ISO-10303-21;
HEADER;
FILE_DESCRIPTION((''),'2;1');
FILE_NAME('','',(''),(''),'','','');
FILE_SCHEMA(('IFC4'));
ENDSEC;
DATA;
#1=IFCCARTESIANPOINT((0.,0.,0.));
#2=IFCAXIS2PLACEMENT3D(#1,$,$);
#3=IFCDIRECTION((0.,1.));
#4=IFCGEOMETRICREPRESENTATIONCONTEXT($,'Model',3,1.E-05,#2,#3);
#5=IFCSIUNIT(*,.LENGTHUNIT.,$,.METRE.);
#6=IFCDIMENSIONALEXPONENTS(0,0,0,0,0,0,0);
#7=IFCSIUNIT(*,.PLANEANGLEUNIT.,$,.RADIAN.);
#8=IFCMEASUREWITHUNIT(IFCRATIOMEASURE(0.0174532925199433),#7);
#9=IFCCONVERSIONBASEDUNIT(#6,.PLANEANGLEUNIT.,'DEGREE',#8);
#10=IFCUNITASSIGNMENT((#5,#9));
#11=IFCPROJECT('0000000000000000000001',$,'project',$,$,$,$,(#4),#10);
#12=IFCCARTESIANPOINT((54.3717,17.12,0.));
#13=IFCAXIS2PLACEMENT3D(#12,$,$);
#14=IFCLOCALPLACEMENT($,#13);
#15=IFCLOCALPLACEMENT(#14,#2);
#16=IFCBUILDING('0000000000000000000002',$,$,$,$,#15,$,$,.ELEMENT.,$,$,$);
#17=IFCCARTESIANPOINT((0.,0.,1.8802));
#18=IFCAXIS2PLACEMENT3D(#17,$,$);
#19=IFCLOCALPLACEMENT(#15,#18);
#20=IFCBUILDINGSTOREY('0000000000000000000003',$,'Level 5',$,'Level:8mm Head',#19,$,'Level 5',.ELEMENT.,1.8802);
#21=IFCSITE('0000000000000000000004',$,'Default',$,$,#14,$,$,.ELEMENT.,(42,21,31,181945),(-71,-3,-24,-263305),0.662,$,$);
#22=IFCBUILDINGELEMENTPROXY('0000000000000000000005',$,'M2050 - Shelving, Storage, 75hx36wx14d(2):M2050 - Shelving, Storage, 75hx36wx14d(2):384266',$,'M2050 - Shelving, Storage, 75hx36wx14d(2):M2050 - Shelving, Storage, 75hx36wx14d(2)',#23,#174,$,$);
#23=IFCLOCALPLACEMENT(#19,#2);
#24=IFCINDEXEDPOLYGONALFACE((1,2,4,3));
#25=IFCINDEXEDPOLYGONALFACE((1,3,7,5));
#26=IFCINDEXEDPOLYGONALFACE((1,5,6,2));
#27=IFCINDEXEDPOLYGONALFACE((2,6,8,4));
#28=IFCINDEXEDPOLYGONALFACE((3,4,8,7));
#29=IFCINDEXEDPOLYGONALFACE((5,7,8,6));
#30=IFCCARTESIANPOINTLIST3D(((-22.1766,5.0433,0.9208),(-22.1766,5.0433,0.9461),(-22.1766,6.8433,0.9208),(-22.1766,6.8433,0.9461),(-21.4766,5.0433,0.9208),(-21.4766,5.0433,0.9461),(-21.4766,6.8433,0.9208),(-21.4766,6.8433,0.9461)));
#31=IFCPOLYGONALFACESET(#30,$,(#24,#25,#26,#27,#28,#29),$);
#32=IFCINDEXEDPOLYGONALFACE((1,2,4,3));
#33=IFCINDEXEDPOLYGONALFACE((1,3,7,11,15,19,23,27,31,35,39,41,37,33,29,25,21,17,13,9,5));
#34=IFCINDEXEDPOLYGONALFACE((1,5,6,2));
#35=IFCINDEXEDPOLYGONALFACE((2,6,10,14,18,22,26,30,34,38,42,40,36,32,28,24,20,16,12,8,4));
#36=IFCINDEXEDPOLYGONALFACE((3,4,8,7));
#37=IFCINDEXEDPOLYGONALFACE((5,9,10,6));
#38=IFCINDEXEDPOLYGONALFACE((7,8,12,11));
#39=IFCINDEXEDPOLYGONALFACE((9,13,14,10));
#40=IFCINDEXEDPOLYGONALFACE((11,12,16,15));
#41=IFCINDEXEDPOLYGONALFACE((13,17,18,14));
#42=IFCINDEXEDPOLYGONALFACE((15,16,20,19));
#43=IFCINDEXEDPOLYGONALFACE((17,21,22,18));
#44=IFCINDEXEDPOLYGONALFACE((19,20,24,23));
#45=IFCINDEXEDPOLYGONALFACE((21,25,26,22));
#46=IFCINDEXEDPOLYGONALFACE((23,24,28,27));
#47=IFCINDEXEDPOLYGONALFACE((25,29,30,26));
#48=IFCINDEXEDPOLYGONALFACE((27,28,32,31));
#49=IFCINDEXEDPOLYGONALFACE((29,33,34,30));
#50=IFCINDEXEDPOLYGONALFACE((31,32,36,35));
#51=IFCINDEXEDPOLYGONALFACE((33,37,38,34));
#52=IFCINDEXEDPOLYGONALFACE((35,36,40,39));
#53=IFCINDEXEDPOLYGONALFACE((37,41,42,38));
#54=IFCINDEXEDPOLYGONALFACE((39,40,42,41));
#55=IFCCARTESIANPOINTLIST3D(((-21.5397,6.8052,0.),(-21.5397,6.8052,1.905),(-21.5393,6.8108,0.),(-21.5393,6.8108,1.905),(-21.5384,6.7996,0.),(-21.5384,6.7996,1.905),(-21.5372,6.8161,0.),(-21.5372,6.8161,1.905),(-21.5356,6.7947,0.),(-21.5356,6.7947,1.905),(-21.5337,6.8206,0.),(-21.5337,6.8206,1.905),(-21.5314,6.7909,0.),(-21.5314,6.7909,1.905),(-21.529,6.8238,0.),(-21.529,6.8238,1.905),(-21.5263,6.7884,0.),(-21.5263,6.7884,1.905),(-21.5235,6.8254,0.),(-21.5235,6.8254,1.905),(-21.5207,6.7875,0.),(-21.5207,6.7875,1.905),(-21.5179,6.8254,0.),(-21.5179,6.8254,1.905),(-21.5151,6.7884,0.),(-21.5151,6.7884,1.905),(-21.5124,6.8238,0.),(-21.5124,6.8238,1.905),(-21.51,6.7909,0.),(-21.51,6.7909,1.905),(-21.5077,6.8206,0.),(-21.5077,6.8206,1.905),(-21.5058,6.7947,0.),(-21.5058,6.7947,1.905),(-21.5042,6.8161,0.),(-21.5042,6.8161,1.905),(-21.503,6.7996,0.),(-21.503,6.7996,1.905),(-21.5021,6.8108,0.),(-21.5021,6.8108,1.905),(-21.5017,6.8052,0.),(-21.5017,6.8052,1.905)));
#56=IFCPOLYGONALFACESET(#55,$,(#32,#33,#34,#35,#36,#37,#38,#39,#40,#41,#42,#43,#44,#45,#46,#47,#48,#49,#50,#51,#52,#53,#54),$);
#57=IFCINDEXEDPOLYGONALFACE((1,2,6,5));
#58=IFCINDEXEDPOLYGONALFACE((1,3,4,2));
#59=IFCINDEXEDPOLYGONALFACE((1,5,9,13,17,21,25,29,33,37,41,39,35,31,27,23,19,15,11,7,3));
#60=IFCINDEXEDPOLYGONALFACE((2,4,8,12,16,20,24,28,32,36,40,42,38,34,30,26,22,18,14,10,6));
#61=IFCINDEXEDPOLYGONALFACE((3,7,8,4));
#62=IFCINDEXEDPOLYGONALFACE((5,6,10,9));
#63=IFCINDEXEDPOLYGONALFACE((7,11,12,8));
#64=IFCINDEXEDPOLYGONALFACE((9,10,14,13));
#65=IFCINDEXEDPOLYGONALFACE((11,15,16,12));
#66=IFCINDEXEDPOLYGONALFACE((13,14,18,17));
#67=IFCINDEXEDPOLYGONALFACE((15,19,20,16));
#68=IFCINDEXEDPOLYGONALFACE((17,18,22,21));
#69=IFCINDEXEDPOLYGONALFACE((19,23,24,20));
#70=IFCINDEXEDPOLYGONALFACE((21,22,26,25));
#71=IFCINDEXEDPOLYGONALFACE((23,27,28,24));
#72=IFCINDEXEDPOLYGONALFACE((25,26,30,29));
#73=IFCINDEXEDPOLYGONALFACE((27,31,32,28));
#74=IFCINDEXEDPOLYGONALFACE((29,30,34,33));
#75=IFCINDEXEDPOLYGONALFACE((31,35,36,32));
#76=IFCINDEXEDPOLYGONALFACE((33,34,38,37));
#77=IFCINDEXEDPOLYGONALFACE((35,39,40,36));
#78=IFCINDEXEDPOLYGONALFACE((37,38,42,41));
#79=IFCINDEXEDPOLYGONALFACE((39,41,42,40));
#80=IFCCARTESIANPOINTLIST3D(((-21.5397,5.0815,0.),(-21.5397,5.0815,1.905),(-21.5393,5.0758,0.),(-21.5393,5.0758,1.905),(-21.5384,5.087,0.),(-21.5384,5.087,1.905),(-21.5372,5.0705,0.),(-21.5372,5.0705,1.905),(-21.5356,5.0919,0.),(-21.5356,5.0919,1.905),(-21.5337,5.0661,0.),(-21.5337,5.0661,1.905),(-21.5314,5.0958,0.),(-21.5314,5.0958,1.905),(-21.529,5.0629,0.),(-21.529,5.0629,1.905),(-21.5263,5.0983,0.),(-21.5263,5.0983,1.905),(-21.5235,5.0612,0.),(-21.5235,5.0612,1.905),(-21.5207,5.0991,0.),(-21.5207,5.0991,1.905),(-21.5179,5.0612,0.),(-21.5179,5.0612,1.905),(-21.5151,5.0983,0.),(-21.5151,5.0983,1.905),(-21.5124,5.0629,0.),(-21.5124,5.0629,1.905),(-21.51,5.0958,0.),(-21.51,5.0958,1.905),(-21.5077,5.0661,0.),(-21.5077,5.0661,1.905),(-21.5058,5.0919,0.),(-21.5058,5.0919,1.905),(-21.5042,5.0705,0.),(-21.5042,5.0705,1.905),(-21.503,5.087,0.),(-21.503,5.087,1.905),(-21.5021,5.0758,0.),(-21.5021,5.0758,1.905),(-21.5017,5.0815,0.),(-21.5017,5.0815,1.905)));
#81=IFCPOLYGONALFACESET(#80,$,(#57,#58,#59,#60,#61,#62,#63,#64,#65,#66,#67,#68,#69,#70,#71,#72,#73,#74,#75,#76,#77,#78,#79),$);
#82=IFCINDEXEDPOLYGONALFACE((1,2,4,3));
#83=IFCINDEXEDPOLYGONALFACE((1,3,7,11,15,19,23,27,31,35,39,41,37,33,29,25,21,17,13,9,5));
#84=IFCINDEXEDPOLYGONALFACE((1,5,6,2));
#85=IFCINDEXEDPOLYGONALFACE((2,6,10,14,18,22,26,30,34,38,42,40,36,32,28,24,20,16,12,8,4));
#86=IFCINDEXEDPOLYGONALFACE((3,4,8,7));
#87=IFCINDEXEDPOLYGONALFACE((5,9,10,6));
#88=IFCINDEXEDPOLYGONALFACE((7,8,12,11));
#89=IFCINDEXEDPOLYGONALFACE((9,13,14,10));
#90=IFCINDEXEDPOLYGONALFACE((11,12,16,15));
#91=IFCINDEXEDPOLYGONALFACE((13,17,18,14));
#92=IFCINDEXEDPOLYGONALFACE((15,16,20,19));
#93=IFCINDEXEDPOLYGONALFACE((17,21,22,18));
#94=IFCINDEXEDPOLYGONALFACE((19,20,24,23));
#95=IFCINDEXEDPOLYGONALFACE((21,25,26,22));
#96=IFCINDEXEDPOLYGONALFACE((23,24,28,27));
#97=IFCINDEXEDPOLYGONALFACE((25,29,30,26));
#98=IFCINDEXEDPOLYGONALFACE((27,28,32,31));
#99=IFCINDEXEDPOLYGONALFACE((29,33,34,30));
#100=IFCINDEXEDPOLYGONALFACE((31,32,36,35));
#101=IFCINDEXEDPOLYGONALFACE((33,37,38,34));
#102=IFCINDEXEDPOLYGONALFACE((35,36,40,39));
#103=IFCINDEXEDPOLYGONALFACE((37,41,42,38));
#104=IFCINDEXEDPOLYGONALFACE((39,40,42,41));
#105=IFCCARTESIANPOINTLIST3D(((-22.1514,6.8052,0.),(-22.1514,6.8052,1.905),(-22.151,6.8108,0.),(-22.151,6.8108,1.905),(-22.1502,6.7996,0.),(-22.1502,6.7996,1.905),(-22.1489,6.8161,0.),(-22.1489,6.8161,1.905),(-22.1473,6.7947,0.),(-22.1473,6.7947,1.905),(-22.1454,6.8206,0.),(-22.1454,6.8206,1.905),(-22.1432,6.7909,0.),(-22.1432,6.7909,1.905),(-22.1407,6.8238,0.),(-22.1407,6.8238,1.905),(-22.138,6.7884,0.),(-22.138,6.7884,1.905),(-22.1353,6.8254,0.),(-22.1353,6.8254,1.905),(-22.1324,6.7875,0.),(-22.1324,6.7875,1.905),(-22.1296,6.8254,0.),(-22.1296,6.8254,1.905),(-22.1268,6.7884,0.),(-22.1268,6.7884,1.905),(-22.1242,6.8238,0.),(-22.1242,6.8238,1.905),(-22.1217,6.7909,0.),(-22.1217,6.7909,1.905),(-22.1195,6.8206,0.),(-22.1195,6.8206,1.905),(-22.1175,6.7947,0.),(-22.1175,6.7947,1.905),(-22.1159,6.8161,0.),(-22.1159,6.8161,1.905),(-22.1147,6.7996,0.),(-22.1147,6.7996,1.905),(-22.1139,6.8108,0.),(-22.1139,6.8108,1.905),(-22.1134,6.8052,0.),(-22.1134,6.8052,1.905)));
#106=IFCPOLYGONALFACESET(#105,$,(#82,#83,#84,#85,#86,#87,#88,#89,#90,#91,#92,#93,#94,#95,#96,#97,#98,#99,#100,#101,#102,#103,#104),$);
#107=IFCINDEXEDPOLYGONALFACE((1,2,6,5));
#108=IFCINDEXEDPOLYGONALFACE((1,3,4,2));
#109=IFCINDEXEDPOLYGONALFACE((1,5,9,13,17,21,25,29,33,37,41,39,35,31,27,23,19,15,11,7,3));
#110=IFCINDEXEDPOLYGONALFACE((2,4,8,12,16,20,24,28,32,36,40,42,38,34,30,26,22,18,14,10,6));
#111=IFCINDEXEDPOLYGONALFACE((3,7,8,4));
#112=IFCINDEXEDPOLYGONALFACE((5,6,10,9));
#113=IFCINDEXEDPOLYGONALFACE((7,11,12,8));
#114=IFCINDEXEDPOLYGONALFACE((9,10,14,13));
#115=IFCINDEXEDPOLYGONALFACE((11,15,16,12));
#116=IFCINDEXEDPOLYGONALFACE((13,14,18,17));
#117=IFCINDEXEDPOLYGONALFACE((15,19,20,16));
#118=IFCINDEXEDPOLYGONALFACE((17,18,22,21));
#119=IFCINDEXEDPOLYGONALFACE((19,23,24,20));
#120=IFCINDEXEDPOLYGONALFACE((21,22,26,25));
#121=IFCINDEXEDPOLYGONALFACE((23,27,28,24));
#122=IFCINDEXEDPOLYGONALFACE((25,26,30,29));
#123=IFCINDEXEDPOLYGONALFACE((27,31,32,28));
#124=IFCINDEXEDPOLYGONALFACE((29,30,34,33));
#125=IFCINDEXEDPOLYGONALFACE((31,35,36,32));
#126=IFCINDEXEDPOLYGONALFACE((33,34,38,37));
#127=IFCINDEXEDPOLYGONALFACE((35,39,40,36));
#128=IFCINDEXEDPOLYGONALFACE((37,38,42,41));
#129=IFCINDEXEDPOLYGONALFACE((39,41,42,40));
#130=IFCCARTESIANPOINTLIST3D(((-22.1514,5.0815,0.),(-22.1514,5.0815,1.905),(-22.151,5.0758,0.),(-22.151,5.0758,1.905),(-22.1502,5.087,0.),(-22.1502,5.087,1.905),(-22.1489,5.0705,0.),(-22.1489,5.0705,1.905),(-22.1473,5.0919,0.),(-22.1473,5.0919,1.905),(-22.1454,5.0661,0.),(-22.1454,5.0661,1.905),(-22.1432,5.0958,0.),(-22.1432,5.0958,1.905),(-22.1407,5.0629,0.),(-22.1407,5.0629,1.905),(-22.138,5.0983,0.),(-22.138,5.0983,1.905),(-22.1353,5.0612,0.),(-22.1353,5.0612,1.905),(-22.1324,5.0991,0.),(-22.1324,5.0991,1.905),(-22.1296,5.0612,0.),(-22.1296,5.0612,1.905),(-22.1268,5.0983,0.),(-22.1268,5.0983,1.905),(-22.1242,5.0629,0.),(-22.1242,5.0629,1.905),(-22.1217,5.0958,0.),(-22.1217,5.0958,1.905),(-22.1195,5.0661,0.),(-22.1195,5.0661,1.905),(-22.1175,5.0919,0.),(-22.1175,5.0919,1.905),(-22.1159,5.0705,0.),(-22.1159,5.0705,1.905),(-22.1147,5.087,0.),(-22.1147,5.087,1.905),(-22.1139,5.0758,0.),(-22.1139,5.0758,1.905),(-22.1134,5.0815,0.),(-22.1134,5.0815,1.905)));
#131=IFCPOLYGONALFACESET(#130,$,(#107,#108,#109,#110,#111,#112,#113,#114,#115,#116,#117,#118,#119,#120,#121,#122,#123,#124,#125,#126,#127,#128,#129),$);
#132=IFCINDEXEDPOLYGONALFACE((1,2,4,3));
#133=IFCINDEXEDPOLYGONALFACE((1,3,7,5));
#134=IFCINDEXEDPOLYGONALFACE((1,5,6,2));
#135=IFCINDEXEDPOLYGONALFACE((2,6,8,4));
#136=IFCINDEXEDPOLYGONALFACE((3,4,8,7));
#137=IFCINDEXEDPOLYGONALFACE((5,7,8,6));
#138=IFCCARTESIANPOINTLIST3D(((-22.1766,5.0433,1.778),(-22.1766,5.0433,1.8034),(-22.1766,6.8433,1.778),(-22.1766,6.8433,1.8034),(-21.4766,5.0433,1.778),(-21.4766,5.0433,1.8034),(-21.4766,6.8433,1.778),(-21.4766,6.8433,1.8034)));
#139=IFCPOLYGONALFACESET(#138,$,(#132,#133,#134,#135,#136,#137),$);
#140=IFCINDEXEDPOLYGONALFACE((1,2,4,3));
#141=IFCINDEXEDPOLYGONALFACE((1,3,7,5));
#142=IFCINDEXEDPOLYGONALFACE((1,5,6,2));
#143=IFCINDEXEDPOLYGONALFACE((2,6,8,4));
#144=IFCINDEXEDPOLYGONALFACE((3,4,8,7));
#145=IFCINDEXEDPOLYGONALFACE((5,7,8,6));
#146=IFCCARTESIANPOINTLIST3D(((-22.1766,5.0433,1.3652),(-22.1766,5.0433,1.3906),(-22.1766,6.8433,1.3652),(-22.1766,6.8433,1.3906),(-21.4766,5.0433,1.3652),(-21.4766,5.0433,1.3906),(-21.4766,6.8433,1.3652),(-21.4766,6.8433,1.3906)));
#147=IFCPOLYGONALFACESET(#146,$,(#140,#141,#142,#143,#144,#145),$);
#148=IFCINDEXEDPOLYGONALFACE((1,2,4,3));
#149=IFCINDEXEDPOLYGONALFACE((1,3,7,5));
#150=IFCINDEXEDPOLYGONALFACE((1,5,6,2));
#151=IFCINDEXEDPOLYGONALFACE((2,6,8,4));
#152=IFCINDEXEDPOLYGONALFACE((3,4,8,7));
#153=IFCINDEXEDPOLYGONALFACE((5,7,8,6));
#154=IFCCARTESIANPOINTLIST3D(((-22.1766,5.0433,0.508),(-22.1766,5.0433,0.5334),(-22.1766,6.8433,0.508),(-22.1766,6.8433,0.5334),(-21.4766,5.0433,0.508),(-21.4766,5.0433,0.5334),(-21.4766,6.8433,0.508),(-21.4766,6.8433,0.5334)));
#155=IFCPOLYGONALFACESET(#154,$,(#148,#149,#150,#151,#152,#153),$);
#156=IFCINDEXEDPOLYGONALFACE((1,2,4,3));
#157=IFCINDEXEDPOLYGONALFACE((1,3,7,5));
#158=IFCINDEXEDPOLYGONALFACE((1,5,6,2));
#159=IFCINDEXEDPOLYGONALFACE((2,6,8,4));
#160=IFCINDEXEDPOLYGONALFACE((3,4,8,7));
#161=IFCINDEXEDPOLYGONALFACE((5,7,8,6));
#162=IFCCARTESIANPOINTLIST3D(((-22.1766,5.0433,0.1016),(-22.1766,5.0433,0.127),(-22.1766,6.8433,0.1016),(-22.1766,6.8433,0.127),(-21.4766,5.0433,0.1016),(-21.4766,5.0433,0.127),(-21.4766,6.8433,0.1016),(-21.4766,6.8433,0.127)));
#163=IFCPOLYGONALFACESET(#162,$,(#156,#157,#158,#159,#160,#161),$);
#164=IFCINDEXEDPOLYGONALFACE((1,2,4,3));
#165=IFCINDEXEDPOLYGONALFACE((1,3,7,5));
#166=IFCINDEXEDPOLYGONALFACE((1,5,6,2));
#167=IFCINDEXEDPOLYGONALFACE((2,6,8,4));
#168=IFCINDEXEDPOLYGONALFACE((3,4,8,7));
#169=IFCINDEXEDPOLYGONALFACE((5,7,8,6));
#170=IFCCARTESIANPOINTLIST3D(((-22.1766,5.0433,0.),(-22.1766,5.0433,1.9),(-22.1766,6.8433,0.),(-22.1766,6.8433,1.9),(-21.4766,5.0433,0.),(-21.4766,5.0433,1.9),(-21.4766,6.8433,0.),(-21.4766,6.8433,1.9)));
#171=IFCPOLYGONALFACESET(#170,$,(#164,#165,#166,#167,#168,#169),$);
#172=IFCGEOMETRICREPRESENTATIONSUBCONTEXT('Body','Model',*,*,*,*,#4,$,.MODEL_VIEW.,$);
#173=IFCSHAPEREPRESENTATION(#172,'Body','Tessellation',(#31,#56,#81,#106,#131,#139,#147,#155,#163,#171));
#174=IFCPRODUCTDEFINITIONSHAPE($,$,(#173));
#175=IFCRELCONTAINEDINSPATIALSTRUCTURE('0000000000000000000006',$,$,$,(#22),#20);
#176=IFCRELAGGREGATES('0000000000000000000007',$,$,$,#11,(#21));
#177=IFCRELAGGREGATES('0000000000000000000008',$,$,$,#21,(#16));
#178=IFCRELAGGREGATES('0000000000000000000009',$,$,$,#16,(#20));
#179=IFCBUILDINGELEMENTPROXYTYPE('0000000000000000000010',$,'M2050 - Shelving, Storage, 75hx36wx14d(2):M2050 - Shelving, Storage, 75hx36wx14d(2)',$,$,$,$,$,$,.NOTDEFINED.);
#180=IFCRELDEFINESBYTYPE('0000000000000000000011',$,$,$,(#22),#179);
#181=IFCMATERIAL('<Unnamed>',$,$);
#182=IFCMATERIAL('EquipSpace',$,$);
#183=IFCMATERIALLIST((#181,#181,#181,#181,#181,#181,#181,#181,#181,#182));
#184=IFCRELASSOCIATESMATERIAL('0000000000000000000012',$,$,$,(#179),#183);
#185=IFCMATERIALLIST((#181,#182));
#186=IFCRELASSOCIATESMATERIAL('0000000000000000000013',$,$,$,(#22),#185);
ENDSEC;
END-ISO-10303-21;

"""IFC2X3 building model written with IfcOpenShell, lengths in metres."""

from ifc_helpers import new_model, entity, si_unit, converted_unit, direction, frame, frame_2d, origin, origin_2d_with_axis, place, context, subcontext, project, spatial, rectangle, circle, extrude, source, transform, mapped, material, material_list, type_object, type_shapes, element, save


model = new_model("IFC2X3")

# Units and contexts
model_context = context("Model", 3, precision=1e-05, world=origin(), true_north=direction((0.0, 1.0)))
body_context = subcontext(model_context, "Body", "Model", "MODEL_VIEW")
ifc_project = project(units=[si_unit("LENGTHUNIT", "METRE"), converted_unit("PLANEANGLEUNIT", "DEGREE", entity("IfcRatioMeasure", 0.0174532925199433), si_unit("PLANEANGLEUNIT", "RADIAN"), dimensions=[0, 0, 0, 0, 0, 0, 0])], contexts=[model_context])

# Site, building, storey
site_placement = place(None, frame((54.3717, 17.12, 0.0)))
site = spatial("IfcSite", under=ifc_project, at=site_placement, Name="Default", CompositionType="ELEMENT", RefLatitude=(42, 21, 31, 181945), RefLongitude=(-71, -3, -24, -263305), RefElevation=0.662)
building_placement = place(site_placement, origin())
building = spatial("IfcBuilding", under=site, at=building_placement, CompositionType="ELEMENT")
storey_placement = place(building_placement, frame((0.0, 0.0, 1.8802)))
storey = spatial("IfcBuildingStorey", under=building, at=storey_placement, Name="Level 5", ObjectType="Level:8mm Head", LongName="Level 5", CompositionType="ELEMENT", Elevation=1.8802)

# Building element proxy
ifc_material_1 = material(Name="<Unnamed>")
ifc_material_2 = material(Name="EquipSpace")
ifc_material_list_1 = material_list([ifc_material_1, ifc_material_1, ifc_material_1, ifc_material_1, ifc_material_1, ifc_material_1, ifc_material_1, ifc_material_1, ifc_material_1, ifc_material_2])
building_element_proxy_type = type_object("IfcBuildingElementProxyType", Name="M2050 - Shelving, Storage, 75hx36wx14d(2):M2050 - Shelving, Storage, 75hx36wx14d(2)", PredefinedType="NOTDEFINED", material=ifc_material_list_1)
shared_shape = source(origin(), body_context, "Body", "SweptSolid", [
    extrude(rectangle(XDim=1.8, YDim=0.7, at=origin_2d_with_axis()), frame((0.0, 0.0, 0.9207), z_axis=(0.0, 0.0, 1.0), x_axis=(-1.0, 0.0, 0.0)), (0.0, 0.0, 1.0), 0.0254),
    extrude(circle(Radius=0.0191, at=origin_2d_with_axis()), frame((0.8633, -0.3059, 0.0), z_axis=(0.0, 0.0, 1.0), x_axis=(-1.0, 0.0, 0.0)), (0.0, 0.0, 1.0), 1.905),
    extrude(circle(Radius=0.0191, at=origin_2d_with_axis()), frame((-0.8633, -0.3059, 0.0)), (0.0, 0.0, 1.0), 1.905),
    extrude(circle(Radius=0.0191, at=origin_2d_with_axis()), frame((0.8633, 0.3059, 0.0), z_axis=(0.0, 0.0, 1.0), x_axis=(-1.0, 0.0, 0.0)), (0.0, 0.0, 1.0), 1.905),
    extrude(circle(Radius=0.0191, at=origin_2d_with_axis()), frame((-0.8633, 0.3059, 0.0)), (0.0, 0.0, 1.0), 1.905),
    extrude(rectangle(XDim=1.8, YDim=0.7, at=origin_2d_with_axis()), frame((0.0, 0.0, 1.778), z_axis=(0.0, 0.0, 1.0), x_axis=(-1.0, 0.0, 0.0)), (0.0, 0.0, 1.0), 0.0254),
    extrude(rectangle(XDim=1.8, YDim=0.7, at=origin_2d_with_axis()), frame((0.0, 0.0, 1.3653), z_axis=(0.0, 0.0, 1.0), x_axis=(-1.0, 0.0, 0.0)), (0.0, 0.0, 1.0), 0.0254),
    extrude(rectangle(XDim=1.8, YDim=0.7, at=origin_2d_with_axis()), frame((0.0, 0.0, 0.508), z_axis=(0.0, 0.0, 1.0), x_axis=(-1.0, 0.0, 0.0)), (0.0, 0.0, 1.0), 0.0254),
    extrude(rectangle(XDim=1.8, YDim=0.7, at=origin_2d_with_axis()), frame((0.0, 0.0, 0.1016), z_axis=(0.0, 0.0, 1.0), x_axis=(-1.0, 0.0, 0.0)), (0.0, 0.0, 1.0), 0.0254),
    extrude(rectangle(XDim=0.7, YDim=1.8, at=frame_2d((0.0, 0.18), x_axis=(1.0, 0.0))), frame((-0.18, 0.0, 0.0), z_axis=(0.0, 0.0, 1.0), x_axis=(0.0, -1.0, 0.0)), (0.0, 0.0, 1.0), 1.9),
])
type_shapes(building_element_proxy_type, [shared_shape])
ifc_material_list_2 = material_list([ifc_material_1, ifc_material_2])
proxy_1_placement = place(storey_placement, frame((-21.8266, 5.9433, 0.0), z_axis=(0.0, 0.0, 1.0), x_axis=(0.0, 1.0, 0.0)))
element("IfcBuildingElementProxy", 1, at=proxy_1_placement, inside=storey, type_object=building_element_proxy_type, material=ifc_material_list_2, Name="M2050 - Shelving, Storage, 75hx36wx14d(2):M2050 - Shelving, Storage, 75hx36wx14d(2):384266", ObjectType="M2050 - Shelving, Storage, 75hx36wx14d(2):M2050 - Shelving, Storage, 75hx36wx14d(2)", context=body_context, shape_type="MappedRepresentation", body=[
    mapped(shared_shape, transform((0.0, 0.0, 0.0), scale=1.0)),
])

save(model, "model.ifc")
